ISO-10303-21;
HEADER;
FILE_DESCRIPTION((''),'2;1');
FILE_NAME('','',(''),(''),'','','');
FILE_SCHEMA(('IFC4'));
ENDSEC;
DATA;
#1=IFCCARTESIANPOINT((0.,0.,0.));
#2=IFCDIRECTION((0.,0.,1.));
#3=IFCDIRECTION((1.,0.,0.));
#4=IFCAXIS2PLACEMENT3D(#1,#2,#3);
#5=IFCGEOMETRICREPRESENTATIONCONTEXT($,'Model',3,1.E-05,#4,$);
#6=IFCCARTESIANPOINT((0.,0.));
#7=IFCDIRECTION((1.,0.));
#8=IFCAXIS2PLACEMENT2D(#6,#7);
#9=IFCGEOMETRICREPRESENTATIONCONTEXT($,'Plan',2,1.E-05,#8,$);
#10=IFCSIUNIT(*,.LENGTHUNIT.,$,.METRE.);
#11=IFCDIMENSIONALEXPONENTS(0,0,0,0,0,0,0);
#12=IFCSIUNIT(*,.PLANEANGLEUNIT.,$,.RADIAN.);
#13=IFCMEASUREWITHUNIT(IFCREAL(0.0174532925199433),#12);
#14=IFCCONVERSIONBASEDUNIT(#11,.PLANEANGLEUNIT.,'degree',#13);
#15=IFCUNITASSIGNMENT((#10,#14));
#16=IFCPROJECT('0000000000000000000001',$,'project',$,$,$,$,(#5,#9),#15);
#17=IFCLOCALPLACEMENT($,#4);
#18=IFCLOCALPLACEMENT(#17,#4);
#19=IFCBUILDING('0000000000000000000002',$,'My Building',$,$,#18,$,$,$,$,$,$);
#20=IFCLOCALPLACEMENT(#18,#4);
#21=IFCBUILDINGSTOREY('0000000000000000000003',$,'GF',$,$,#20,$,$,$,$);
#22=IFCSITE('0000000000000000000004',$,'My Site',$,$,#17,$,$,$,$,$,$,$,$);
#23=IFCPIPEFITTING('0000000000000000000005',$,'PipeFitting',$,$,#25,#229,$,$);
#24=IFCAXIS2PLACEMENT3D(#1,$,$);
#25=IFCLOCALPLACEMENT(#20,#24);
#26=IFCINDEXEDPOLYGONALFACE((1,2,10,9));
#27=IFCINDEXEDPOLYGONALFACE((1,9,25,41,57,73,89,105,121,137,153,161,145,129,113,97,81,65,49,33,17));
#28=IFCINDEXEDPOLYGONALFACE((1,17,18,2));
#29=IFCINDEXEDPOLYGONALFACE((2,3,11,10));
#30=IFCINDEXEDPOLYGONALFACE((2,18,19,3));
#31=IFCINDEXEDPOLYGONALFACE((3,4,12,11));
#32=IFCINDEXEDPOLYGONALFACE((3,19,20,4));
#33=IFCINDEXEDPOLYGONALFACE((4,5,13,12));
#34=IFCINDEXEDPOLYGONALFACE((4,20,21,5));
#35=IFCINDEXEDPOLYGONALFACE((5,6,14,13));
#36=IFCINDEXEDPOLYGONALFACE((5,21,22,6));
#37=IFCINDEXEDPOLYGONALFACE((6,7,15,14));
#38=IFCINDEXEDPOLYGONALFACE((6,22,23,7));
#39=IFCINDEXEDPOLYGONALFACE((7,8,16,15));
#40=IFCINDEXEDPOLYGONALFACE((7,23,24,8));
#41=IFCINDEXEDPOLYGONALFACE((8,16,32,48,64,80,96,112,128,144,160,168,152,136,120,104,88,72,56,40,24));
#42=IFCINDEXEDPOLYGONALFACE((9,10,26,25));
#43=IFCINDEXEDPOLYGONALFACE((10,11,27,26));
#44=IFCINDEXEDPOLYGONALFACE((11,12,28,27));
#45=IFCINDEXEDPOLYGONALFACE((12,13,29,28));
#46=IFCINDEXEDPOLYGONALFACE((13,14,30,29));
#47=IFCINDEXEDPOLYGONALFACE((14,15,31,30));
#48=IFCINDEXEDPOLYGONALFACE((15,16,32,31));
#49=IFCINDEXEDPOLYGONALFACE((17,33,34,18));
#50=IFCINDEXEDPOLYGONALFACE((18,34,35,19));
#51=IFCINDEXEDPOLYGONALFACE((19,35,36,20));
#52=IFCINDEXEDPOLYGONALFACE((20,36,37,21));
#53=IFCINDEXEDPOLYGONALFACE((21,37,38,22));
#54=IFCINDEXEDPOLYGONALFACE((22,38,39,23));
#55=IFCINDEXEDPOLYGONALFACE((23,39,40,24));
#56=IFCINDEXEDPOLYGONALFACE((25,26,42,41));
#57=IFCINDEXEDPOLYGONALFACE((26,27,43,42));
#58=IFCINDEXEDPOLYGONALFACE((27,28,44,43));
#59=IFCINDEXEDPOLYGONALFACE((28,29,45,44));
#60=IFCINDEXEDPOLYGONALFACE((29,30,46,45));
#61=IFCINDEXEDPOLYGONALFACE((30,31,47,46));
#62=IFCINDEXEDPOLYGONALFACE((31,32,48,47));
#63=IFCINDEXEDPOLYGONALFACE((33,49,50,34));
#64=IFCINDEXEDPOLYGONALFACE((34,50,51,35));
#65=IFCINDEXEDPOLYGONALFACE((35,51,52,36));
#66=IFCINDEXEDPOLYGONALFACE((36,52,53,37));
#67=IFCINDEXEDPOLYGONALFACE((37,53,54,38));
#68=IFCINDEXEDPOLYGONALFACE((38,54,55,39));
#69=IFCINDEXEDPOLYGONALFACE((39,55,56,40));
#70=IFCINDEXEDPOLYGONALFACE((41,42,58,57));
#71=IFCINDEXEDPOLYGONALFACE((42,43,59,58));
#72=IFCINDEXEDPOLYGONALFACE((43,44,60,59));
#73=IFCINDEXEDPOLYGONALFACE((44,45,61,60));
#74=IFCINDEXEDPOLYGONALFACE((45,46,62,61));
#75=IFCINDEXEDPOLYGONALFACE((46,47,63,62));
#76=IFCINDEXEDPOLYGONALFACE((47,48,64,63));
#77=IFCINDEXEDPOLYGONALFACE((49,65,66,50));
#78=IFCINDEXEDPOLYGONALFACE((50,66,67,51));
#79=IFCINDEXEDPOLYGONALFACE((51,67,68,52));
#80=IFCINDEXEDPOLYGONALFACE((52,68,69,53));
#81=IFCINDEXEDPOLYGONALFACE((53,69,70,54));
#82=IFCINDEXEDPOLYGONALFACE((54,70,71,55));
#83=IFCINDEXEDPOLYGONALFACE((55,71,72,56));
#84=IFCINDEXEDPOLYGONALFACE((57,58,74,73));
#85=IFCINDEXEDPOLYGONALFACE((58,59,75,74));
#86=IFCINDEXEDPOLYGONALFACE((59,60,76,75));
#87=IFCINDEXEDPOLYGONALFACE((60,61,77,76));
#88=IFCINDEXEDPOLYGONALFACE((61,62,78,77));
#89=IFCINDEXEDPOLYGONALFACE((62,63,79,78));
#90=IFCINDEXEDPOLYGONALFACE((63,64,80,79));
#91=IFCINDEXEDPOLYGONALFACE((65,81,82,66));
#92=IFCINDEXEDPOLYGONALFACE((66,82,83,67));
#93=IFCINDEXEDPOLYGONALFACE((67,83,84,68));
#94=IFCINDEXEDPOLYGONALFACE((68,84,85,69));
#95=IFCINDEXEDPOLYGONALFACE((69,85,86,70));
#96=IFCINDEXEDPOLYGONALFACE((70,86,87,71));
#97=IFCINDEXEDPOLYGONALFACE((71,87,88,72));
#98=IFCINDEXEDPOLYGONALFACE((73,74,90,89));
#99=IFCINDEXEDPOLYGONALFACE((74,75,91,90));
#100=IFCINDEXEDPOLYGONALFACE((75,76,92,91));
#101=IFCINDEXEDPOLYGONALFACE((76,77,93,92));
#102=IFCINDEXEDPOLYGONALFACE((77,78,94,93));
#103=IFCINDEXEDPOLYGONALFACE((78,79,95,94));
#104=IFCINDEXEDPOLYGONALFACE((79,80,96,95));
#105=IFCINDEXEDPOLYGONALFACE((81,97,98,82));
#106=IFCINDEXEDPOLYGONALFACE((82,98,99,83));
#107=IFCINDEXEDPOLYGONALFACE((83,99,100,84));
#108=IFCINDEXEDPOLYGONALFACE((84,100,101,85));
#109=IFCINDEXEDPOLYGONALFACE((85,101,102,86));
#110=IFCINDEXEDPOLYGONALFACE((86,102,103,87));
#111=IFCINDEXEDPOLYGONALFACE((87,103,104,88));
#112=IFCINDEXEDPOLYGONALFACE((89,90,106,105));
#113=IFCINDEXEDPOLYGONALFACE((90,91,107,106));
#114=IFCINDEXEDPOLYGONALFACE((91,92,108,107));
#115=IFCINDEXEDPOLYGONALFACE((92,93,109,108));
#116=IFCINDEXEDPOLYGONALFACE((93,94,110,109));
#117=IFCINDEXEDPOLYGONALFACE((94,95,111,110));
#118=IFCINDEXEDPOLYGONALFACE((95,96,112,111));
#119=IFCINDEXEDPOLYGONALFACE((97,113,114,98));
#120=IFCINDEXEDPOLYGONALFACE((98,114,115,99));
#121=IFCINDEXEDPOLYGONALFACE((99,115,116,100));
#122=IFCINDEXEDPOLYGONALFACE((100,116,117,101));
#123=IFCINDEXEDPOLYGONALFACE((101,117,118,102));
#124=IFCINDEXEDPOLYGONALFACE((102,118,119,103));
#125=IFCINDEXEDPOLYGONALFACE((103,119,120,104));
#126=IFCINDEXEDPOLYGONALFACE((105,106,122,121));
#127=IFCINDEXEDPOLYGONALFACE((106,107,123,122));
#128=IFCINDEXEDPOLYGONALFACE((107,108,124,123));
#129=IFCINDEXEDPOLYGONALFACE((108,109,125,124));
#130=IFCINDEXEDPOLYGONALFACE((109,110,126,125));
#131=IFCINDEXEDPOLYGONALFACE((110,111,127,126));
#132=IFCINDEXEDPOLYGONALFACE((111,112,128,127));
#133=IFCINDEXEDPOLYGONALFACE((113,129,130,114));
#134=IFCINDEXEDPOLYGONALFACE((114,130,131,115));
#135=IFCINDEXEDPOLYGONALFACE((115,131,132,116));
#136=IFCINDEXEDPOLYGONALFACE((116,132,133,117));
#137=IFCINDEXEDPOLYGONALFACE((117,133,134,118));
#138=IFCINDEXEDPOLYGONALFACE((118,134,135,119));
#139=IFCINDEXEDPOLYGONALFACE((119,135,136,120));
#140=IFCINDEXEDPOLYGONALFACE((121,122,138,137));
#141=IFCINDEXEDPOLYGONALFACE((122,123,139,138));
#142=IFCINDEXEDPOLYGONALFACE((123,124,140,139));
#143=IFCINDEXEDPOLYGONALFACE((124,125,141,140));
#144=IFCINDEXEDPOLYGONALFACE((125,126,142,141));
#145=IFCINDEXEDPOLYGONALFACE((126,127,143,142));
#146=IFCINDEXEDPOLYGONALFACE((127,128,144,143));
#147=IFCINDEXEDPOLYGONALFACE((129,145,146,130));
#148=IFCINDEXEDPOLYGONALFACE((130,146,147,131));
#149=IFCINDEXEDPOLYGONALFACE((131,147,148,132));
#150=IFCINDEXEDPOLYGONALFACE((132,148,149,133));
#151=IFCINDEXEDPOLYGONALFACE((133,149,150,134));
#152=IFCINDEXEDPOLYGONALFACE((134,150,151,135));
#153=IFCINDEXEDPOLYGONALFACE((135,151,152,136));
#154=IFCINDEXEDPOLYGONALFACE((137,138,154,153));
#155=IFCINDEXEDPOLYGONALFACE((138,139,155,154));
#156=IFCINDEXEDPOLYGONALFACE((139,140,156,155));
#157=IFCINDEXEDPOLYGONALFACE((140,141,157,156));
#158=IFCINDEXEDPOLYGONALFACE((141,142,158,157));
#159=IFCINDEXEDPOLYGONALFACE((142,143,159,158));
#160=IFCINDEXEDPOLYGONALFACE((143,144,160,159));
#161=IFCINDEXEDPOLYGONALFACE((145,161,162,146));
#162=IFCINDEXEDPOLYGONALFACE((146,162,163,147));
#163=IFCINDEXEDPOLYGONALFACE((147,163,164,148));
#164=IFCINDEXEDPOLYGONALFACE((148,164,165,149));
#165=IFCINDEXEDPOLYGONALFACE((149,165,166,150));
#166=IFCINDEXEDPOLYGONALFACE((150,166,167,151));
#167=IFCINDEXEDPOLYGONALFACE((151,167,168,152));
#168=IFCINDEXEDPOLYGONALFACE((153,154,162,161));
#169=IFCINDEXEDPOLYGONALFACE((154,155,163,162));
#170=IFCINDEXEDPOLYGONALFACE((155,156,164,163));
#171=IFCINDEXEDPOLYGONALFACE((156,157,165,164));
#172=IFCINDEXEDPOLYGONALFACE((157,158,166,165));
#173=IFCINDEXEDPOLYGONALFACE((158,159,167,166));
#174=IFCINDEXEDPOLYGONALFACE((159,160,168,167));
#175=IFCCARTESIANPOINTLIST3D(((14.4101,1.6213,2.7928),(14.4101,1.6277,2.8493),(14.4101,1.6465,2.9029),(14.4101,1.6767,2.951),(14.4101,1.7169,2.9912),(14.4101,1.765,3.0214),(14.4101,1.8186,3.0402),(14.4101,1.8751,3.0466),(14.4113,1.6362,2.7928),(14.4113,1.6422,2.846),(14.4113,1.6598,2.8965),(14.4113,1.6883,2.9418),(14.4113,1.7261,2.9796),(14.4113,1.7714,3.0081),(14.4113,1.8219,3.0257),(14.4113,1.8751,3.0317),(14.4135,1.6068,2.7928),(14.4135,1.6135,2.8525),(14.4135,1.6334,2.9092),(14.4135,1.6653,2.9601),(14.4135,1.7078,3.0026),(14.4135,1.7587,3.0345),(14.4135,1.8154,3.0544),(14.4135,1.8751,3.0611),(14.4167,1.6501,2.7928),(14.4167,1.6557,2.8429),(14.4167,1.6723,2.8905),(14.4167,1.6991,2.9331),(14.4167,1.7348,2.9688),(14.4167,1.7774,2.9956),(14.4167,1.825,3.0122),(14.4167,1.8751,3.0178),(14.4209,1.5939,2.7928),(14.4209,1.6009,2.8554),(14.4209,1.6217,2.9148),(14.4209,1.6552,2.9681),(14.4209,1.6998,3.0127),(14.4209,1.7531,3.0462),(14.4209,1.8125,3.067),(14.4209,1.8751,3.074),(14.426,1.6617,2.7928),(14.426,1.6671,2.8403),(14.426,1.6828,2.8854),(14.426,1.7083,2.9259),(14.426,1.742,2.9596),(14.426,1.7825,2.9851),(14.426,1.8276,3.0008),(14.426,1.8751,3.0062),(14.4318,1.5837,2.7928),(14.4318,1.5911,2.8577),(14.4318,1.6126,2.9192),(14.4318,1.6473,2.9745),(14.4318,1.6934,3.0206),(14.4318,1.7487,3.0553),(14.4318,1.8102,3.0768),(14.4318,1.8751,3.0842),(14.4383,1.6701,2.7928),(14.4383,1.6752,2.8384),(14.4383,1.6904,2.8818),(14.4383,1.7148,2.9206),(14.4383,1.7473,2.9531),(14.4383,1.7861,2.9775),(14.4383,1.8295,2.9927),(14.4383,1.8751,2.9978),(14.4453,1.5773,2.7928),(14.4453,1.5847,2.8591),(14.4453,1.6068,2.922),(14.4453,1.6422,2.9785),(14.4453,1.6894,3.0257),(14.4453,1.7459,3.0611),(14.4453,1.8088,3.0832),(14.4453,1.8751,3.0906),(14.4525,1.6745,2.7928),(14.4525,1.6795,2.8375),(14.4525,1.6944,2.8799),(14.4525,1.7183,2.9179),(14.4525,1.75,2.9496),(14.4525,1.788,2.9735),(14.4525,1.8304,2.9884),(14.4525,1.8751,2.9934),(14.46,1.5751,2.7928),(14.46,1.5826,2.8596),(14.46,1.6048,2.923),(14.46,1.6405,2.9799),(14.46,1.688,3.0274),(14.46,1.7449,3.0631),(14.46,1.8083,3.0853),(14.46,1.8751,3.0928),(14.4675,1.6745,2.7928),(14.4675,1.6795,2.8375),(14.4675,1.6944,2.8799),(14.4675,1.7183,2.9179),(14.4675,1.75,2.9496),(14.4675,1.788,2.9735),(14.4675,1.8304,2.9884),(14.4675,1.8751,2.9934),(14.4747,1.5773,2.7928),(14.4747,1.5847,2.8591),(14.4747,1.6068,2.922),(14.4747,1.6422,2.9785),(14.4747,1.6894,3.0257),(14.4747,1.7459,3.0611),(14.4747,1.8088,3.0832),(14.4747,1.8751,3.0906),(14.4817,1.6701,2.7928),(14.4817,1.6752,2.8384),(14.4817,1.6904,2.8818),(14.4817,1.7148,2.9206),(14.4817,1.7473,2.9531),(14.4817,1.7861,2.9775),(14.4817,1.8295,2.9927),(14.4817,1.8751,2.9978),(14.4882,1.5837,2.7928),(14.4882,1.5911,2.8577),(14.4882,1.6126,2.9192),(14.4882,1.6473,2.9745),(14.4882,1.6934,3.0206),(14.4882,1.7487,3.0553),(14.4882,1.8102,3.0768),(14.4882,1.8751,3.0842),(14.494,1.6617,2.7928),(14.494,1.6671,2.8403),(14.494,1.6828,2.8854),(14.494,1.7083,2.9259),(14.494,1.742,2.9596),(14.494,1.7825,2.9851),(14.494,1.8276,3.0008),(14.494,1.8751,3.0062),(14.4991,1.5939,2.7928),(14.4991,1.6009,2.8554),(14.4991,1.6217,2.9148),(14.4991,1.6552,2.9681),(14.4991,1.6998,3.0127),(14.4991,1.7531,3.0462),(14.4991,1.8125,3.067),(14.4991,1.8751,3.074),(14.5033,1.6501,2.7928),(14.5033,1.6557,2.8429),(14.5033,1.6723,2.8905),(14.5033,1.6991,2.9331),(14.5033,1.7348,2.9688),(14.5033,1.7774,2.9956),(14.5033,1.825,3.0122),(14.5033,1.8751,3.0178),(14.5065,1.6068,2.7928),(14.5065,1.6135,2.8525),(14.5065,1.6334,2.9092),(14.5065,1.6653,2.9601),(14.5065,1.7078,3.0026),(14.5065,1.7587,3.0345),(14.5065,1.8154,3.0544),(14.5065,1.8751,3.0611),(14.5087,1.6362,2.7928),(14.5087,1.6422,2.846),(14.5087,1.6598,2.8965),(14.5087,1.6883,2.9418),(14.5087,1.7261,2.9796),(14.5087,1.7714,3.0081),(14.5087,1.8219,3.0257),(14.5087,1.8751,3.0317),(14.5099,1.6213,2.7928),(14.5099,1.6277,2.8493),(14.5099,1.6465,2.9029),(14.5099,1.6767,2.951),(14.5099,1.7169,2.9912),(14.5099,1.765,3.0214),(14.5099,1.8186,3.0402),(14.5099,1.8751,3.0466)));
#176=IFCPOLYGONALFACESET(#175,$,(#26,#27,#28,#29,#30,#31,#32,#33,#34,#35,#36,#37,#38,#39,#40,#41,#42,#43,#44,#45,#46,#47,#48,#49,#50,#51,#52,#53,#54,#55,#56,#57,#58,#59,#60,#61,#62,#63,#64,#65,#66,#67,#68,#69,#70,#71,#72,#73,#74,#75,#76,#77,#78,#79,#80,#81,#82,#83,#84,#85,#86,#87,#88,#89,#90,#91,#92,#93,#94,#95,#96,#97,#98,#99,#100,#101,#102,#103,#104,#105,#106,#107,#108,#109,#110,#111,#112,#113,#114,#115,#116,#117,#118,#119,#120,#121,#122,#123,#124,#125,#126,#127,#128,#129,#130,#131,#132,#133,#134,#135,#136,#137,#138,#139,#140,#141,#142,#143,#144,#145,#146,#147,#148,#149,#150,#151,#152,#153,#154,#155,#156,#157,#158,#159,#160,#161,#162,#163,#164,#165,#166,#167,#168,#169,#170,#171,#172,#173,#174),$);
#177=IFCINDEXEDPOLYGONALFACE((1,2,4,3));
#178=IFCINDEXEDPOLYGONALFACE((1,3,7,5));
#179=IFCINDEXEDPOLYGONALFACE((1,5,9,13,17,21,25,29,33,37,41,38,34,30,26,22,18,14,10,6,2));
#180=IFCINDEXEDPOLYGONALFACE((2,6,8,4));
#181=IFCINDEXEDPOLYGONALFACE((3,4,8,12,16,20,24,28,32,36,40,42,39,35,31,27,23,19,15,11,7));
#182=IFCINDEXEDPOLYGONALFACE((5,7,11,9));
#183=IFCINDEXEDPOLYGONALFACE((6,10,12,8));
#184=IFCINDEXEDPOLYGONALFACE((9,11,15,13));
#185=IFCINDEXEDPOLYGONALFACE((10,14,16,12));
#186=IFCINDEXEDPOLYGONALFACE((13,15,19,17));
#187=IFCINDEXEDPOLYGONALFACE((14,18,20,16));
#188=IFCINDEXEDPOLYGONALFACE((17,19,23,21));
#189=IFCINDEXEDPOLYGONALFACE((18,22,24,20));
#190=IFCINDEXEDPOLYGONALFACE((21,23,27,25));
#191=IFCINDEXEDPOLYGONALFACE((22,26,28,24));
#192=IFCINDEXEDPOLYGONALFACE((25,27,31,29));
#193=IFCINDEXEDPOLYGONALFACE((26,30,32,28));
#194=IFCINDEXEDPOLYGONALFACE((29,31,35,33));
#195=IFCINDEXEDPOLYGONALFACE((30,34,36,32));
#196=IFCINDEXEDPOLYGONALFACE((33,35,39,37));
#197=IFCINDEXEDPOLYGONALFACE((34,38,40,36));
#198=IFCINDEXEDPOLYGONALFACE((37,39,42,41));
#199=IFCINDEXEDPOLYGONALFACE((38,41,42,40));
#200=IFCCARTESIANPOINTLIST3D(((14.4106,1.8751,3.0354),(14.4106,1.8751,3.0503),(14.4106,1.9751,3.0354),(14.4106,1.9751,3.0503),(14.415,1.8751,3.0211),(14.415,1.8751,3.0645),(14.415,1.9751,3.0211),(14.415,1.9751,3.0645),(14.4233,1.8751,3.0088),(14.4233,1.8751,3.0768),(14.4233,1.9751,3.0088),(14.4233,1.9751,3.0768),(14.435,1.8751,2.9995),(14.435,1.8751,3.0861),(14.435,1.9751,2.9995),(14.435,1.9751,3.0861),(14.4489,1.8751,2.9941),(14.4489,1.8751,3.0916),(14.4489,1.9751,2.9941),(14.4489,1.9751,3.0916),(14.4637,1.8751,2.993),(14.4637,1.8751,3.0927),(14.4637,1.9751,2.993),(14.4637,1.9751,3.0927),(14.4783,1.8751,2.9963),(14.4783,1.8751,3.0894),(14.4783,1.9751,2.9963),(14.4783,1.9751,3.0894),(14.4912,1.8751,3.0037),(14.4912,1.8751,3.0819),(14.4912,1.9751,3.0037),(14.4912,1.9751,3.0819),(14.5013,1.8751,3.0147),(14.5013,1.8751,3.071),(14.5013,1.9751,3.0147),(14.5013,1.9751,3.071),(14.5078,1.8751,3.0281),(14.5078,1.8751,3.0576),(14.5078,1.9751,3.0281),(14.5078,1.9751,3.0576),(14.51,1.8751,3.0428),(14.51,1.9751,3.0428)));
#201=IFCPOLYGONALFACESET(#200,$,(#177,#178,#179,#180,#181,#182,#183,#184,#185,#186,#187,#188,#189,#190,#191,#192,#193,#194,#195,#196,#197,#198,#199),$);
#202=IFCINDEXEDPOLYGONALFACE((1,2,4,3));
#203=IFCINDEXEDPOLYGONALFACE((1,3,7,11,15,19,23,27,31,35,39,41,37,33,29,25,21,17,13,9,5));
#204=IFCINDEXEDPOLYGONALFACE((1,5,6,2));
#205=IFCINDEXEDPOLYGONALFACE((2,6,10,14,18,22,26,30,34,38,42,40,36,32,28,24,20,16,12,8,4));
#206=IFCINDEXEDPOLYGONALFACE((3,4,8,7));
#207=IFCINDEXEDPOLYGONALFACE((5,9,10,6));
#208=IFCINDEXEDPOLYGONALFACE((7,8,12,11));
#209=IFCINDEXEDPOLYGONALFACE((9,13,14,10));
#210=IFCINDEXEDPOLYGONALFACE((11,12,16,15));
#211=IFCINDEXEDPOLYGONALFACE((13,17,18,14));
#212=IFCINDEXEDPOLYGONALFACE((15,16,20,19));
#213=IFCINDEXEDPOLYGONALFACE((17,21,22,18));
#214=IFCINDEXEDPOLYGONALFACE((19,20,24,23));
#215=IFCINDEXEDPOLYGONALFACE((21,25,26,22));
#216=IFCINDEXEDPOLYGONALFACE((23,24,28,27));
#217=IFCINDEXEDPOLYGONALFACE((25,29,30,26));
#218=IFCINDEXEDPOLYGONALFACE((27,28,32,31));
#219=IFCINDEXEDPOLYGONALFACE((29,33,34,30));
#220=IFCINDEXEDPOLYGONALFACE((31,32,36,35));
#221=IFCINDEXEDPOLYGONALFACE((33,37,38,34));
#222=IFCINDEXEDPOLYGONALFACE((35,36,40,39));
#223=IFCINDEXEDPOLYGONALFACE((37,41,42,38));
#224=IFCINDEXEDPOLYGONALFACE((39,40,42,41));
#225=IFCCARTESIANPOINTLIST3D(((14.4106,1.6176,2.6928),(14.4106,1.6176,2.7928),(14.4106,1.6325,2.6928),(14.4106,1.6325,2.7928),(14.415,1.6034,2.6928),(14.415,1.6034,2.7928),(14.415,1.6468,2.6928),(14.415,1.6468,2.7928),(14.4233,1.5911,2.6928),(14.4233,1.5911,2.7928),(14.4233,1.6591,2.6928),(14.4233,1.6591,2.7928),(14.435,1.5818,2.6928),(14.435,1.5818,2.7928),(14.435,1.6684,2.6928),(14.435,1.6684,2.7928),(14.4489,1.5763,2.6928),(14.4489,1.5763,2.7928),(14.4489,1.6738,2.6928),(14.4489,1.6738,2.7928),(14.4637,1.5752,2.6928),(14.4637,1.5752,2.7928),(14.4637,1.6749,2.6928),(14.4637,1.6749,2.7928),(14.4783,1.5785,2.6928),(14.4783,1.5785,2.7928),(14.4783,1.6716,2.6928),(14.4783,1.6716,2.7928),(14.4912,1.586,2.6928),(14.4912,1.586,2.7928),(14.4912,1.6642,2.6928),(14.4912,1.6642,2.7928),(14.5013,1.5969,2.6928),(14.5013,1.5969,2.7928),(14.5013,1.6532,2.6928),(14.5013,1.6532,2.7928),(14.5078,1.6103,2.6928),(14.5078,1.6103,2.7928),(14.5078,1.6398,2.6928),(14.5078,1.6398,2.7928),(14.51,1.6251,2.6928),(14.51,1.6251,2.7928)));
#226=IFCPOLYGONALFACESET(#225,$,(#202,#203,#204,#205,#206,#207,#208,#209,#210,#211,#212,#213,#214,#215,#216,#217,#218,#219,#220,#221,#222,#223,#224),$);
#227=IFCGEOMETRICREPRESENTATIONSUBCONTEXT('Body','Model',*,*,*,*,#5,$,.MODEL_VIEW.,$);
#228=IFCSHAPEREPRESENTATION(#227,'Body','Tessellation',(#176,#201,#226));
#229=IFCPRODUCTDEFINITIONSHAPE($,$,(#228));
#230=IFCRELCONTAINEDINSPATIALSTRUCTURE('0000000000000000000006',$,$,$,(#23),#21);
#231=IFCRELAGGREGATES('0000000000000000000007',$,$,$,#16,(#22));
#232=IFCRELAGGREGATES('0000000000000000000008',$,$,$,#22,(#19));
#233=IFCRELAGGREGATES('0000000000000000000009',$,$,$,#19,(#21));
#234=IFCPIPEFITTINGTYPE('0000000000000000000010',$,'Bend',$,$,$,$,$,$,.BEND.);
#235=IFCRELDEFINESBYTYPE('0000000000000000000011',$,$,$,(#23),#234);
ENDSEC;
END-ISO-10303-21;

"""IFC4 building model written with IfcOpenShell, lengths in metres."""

from ifc_helpers import new_model, entity, si_unit, converted_unit, frame, origin_with_axes, origin_2d_with_axis, place, context, subcontext, project, spatial, line, indexed_curve, circle, outline, extrude, source, transform, mapped, type_object, type_shapes, element, save


model = new_model("IFC4")

# Units and contexts
model_context = context("Model", 3, precision=1e-05, world=origin_with_axes())
plan_context = context("Plan", 2, precision=1e-05, world=origin_2d_with_axis())
body_context = subcontext(model_context, "Body", "Model", "MODEL_VIEW")
ifc_project = project(units=[si_unit("LENGTHUNIT", "METRE"), converted_unit("PLANEANGLEUNIT", "degree", entity("IfcReal", 0.0174532925199433), si_unit("PLANEANGLEUNIT", "RADIAN"), dimensions=[0, 0, 0, 0, 0, 0, 0])], contexts=[model_context, plan_context])

# Site, building, storey
site_placement = place(None, origin_with_axes())
site = spatial("IfcSite", under=ifc_project, at=site_placement, Name="My Site")
building_placement = place(site_placement, origin_with_axes())
building = spatial("IfcBuilding", under=site, at=building_placement, Name="My Building")
storey_placement = place(building_placement, origin_with_axes())
storey = spatial("IfcBuildingStorey", under=building, at=storey_placement, Name="GF")

# Pipe fitting, opening
pipe_fitting_type = type_object("IfcPipeFittingType", Name="Bend", PredefinedType="BEND")
shared_shape = source(origin_with_axes(), body_context, "Body", "SolidModel", [
    entity("IfcSweptDiskSolid", entity("IfcIndexedPolyCurve", entity("IfcCartesianPointList3D", [[0.0, 0.0, 0.1], [0.0, -0.0732, 0.2768], [0.0, -0.25, 0.35]]), [entity("IfcArcIndex", [1, 2, 3])]), 0.05),
    extrude(circle(Radius=0.05), origin_with_axes(), (0.0, 0.0, 1.0), 0.1),
    extrude(circle(Radius=0.05), frame((0.0, -0.25, 0.35), z_axis=(0.0, -1.0, 0.0), x_axis=(1.0, 0.0, 0.0)), (0.0, 0.0, 1.0), 0.1),
])
type_shapes(pipe_fitting_type, [shared_shape])
pipe_fitting_1_placement = place(storey_placement, frame((14.46, 1.9751, 3.0428), z_axis=(0.0, -1.0, 0.0), x_axis=(1.0, 0.0, 0.0)))
pipe_fitting_1 = element("IfcPipeFitting", 1, at=pipe_fitting_1_placement, inside=storey, type_object=pipe_fitting_type, Name="PipeFitting", context=body_context, shape_type="MappedRepresentation", body=[
    mapped(shared_shape, transform((0.0, 0.0, 0.0), x_axis=(1.0, 0.0, 0.0), y_axis=(0.0, 1.0, 0.0), z_axis=(0.0, 0.0, 1.0), scale=1.0)),
])
opening_1_placement = place(pipe_fitting_1_placement, frame((-14.46, -3.0428, 1.9751), z_axis=(0.0, 1.0, 0.0), x_axis=(1.0, 0.0, 0.0)))
element("IfcOpeningElement", 2, at=opening_1_placement, cuts=pipe_fitting_1, PredefinedType="OPENING", context=body_context, shape_type="SweptSolid", body=[
    extrude(outline(indexed_curve([(0.0, 0.0), (0.5, 0.0), (0.5, 0.5), (0.0, 0.5)], segments=[line(1, 2, 3, 4, 1)])), origin_with_axes(), (0.0, 0.0, 1.0), 0.5),
])

save(model, "model.ifc")
